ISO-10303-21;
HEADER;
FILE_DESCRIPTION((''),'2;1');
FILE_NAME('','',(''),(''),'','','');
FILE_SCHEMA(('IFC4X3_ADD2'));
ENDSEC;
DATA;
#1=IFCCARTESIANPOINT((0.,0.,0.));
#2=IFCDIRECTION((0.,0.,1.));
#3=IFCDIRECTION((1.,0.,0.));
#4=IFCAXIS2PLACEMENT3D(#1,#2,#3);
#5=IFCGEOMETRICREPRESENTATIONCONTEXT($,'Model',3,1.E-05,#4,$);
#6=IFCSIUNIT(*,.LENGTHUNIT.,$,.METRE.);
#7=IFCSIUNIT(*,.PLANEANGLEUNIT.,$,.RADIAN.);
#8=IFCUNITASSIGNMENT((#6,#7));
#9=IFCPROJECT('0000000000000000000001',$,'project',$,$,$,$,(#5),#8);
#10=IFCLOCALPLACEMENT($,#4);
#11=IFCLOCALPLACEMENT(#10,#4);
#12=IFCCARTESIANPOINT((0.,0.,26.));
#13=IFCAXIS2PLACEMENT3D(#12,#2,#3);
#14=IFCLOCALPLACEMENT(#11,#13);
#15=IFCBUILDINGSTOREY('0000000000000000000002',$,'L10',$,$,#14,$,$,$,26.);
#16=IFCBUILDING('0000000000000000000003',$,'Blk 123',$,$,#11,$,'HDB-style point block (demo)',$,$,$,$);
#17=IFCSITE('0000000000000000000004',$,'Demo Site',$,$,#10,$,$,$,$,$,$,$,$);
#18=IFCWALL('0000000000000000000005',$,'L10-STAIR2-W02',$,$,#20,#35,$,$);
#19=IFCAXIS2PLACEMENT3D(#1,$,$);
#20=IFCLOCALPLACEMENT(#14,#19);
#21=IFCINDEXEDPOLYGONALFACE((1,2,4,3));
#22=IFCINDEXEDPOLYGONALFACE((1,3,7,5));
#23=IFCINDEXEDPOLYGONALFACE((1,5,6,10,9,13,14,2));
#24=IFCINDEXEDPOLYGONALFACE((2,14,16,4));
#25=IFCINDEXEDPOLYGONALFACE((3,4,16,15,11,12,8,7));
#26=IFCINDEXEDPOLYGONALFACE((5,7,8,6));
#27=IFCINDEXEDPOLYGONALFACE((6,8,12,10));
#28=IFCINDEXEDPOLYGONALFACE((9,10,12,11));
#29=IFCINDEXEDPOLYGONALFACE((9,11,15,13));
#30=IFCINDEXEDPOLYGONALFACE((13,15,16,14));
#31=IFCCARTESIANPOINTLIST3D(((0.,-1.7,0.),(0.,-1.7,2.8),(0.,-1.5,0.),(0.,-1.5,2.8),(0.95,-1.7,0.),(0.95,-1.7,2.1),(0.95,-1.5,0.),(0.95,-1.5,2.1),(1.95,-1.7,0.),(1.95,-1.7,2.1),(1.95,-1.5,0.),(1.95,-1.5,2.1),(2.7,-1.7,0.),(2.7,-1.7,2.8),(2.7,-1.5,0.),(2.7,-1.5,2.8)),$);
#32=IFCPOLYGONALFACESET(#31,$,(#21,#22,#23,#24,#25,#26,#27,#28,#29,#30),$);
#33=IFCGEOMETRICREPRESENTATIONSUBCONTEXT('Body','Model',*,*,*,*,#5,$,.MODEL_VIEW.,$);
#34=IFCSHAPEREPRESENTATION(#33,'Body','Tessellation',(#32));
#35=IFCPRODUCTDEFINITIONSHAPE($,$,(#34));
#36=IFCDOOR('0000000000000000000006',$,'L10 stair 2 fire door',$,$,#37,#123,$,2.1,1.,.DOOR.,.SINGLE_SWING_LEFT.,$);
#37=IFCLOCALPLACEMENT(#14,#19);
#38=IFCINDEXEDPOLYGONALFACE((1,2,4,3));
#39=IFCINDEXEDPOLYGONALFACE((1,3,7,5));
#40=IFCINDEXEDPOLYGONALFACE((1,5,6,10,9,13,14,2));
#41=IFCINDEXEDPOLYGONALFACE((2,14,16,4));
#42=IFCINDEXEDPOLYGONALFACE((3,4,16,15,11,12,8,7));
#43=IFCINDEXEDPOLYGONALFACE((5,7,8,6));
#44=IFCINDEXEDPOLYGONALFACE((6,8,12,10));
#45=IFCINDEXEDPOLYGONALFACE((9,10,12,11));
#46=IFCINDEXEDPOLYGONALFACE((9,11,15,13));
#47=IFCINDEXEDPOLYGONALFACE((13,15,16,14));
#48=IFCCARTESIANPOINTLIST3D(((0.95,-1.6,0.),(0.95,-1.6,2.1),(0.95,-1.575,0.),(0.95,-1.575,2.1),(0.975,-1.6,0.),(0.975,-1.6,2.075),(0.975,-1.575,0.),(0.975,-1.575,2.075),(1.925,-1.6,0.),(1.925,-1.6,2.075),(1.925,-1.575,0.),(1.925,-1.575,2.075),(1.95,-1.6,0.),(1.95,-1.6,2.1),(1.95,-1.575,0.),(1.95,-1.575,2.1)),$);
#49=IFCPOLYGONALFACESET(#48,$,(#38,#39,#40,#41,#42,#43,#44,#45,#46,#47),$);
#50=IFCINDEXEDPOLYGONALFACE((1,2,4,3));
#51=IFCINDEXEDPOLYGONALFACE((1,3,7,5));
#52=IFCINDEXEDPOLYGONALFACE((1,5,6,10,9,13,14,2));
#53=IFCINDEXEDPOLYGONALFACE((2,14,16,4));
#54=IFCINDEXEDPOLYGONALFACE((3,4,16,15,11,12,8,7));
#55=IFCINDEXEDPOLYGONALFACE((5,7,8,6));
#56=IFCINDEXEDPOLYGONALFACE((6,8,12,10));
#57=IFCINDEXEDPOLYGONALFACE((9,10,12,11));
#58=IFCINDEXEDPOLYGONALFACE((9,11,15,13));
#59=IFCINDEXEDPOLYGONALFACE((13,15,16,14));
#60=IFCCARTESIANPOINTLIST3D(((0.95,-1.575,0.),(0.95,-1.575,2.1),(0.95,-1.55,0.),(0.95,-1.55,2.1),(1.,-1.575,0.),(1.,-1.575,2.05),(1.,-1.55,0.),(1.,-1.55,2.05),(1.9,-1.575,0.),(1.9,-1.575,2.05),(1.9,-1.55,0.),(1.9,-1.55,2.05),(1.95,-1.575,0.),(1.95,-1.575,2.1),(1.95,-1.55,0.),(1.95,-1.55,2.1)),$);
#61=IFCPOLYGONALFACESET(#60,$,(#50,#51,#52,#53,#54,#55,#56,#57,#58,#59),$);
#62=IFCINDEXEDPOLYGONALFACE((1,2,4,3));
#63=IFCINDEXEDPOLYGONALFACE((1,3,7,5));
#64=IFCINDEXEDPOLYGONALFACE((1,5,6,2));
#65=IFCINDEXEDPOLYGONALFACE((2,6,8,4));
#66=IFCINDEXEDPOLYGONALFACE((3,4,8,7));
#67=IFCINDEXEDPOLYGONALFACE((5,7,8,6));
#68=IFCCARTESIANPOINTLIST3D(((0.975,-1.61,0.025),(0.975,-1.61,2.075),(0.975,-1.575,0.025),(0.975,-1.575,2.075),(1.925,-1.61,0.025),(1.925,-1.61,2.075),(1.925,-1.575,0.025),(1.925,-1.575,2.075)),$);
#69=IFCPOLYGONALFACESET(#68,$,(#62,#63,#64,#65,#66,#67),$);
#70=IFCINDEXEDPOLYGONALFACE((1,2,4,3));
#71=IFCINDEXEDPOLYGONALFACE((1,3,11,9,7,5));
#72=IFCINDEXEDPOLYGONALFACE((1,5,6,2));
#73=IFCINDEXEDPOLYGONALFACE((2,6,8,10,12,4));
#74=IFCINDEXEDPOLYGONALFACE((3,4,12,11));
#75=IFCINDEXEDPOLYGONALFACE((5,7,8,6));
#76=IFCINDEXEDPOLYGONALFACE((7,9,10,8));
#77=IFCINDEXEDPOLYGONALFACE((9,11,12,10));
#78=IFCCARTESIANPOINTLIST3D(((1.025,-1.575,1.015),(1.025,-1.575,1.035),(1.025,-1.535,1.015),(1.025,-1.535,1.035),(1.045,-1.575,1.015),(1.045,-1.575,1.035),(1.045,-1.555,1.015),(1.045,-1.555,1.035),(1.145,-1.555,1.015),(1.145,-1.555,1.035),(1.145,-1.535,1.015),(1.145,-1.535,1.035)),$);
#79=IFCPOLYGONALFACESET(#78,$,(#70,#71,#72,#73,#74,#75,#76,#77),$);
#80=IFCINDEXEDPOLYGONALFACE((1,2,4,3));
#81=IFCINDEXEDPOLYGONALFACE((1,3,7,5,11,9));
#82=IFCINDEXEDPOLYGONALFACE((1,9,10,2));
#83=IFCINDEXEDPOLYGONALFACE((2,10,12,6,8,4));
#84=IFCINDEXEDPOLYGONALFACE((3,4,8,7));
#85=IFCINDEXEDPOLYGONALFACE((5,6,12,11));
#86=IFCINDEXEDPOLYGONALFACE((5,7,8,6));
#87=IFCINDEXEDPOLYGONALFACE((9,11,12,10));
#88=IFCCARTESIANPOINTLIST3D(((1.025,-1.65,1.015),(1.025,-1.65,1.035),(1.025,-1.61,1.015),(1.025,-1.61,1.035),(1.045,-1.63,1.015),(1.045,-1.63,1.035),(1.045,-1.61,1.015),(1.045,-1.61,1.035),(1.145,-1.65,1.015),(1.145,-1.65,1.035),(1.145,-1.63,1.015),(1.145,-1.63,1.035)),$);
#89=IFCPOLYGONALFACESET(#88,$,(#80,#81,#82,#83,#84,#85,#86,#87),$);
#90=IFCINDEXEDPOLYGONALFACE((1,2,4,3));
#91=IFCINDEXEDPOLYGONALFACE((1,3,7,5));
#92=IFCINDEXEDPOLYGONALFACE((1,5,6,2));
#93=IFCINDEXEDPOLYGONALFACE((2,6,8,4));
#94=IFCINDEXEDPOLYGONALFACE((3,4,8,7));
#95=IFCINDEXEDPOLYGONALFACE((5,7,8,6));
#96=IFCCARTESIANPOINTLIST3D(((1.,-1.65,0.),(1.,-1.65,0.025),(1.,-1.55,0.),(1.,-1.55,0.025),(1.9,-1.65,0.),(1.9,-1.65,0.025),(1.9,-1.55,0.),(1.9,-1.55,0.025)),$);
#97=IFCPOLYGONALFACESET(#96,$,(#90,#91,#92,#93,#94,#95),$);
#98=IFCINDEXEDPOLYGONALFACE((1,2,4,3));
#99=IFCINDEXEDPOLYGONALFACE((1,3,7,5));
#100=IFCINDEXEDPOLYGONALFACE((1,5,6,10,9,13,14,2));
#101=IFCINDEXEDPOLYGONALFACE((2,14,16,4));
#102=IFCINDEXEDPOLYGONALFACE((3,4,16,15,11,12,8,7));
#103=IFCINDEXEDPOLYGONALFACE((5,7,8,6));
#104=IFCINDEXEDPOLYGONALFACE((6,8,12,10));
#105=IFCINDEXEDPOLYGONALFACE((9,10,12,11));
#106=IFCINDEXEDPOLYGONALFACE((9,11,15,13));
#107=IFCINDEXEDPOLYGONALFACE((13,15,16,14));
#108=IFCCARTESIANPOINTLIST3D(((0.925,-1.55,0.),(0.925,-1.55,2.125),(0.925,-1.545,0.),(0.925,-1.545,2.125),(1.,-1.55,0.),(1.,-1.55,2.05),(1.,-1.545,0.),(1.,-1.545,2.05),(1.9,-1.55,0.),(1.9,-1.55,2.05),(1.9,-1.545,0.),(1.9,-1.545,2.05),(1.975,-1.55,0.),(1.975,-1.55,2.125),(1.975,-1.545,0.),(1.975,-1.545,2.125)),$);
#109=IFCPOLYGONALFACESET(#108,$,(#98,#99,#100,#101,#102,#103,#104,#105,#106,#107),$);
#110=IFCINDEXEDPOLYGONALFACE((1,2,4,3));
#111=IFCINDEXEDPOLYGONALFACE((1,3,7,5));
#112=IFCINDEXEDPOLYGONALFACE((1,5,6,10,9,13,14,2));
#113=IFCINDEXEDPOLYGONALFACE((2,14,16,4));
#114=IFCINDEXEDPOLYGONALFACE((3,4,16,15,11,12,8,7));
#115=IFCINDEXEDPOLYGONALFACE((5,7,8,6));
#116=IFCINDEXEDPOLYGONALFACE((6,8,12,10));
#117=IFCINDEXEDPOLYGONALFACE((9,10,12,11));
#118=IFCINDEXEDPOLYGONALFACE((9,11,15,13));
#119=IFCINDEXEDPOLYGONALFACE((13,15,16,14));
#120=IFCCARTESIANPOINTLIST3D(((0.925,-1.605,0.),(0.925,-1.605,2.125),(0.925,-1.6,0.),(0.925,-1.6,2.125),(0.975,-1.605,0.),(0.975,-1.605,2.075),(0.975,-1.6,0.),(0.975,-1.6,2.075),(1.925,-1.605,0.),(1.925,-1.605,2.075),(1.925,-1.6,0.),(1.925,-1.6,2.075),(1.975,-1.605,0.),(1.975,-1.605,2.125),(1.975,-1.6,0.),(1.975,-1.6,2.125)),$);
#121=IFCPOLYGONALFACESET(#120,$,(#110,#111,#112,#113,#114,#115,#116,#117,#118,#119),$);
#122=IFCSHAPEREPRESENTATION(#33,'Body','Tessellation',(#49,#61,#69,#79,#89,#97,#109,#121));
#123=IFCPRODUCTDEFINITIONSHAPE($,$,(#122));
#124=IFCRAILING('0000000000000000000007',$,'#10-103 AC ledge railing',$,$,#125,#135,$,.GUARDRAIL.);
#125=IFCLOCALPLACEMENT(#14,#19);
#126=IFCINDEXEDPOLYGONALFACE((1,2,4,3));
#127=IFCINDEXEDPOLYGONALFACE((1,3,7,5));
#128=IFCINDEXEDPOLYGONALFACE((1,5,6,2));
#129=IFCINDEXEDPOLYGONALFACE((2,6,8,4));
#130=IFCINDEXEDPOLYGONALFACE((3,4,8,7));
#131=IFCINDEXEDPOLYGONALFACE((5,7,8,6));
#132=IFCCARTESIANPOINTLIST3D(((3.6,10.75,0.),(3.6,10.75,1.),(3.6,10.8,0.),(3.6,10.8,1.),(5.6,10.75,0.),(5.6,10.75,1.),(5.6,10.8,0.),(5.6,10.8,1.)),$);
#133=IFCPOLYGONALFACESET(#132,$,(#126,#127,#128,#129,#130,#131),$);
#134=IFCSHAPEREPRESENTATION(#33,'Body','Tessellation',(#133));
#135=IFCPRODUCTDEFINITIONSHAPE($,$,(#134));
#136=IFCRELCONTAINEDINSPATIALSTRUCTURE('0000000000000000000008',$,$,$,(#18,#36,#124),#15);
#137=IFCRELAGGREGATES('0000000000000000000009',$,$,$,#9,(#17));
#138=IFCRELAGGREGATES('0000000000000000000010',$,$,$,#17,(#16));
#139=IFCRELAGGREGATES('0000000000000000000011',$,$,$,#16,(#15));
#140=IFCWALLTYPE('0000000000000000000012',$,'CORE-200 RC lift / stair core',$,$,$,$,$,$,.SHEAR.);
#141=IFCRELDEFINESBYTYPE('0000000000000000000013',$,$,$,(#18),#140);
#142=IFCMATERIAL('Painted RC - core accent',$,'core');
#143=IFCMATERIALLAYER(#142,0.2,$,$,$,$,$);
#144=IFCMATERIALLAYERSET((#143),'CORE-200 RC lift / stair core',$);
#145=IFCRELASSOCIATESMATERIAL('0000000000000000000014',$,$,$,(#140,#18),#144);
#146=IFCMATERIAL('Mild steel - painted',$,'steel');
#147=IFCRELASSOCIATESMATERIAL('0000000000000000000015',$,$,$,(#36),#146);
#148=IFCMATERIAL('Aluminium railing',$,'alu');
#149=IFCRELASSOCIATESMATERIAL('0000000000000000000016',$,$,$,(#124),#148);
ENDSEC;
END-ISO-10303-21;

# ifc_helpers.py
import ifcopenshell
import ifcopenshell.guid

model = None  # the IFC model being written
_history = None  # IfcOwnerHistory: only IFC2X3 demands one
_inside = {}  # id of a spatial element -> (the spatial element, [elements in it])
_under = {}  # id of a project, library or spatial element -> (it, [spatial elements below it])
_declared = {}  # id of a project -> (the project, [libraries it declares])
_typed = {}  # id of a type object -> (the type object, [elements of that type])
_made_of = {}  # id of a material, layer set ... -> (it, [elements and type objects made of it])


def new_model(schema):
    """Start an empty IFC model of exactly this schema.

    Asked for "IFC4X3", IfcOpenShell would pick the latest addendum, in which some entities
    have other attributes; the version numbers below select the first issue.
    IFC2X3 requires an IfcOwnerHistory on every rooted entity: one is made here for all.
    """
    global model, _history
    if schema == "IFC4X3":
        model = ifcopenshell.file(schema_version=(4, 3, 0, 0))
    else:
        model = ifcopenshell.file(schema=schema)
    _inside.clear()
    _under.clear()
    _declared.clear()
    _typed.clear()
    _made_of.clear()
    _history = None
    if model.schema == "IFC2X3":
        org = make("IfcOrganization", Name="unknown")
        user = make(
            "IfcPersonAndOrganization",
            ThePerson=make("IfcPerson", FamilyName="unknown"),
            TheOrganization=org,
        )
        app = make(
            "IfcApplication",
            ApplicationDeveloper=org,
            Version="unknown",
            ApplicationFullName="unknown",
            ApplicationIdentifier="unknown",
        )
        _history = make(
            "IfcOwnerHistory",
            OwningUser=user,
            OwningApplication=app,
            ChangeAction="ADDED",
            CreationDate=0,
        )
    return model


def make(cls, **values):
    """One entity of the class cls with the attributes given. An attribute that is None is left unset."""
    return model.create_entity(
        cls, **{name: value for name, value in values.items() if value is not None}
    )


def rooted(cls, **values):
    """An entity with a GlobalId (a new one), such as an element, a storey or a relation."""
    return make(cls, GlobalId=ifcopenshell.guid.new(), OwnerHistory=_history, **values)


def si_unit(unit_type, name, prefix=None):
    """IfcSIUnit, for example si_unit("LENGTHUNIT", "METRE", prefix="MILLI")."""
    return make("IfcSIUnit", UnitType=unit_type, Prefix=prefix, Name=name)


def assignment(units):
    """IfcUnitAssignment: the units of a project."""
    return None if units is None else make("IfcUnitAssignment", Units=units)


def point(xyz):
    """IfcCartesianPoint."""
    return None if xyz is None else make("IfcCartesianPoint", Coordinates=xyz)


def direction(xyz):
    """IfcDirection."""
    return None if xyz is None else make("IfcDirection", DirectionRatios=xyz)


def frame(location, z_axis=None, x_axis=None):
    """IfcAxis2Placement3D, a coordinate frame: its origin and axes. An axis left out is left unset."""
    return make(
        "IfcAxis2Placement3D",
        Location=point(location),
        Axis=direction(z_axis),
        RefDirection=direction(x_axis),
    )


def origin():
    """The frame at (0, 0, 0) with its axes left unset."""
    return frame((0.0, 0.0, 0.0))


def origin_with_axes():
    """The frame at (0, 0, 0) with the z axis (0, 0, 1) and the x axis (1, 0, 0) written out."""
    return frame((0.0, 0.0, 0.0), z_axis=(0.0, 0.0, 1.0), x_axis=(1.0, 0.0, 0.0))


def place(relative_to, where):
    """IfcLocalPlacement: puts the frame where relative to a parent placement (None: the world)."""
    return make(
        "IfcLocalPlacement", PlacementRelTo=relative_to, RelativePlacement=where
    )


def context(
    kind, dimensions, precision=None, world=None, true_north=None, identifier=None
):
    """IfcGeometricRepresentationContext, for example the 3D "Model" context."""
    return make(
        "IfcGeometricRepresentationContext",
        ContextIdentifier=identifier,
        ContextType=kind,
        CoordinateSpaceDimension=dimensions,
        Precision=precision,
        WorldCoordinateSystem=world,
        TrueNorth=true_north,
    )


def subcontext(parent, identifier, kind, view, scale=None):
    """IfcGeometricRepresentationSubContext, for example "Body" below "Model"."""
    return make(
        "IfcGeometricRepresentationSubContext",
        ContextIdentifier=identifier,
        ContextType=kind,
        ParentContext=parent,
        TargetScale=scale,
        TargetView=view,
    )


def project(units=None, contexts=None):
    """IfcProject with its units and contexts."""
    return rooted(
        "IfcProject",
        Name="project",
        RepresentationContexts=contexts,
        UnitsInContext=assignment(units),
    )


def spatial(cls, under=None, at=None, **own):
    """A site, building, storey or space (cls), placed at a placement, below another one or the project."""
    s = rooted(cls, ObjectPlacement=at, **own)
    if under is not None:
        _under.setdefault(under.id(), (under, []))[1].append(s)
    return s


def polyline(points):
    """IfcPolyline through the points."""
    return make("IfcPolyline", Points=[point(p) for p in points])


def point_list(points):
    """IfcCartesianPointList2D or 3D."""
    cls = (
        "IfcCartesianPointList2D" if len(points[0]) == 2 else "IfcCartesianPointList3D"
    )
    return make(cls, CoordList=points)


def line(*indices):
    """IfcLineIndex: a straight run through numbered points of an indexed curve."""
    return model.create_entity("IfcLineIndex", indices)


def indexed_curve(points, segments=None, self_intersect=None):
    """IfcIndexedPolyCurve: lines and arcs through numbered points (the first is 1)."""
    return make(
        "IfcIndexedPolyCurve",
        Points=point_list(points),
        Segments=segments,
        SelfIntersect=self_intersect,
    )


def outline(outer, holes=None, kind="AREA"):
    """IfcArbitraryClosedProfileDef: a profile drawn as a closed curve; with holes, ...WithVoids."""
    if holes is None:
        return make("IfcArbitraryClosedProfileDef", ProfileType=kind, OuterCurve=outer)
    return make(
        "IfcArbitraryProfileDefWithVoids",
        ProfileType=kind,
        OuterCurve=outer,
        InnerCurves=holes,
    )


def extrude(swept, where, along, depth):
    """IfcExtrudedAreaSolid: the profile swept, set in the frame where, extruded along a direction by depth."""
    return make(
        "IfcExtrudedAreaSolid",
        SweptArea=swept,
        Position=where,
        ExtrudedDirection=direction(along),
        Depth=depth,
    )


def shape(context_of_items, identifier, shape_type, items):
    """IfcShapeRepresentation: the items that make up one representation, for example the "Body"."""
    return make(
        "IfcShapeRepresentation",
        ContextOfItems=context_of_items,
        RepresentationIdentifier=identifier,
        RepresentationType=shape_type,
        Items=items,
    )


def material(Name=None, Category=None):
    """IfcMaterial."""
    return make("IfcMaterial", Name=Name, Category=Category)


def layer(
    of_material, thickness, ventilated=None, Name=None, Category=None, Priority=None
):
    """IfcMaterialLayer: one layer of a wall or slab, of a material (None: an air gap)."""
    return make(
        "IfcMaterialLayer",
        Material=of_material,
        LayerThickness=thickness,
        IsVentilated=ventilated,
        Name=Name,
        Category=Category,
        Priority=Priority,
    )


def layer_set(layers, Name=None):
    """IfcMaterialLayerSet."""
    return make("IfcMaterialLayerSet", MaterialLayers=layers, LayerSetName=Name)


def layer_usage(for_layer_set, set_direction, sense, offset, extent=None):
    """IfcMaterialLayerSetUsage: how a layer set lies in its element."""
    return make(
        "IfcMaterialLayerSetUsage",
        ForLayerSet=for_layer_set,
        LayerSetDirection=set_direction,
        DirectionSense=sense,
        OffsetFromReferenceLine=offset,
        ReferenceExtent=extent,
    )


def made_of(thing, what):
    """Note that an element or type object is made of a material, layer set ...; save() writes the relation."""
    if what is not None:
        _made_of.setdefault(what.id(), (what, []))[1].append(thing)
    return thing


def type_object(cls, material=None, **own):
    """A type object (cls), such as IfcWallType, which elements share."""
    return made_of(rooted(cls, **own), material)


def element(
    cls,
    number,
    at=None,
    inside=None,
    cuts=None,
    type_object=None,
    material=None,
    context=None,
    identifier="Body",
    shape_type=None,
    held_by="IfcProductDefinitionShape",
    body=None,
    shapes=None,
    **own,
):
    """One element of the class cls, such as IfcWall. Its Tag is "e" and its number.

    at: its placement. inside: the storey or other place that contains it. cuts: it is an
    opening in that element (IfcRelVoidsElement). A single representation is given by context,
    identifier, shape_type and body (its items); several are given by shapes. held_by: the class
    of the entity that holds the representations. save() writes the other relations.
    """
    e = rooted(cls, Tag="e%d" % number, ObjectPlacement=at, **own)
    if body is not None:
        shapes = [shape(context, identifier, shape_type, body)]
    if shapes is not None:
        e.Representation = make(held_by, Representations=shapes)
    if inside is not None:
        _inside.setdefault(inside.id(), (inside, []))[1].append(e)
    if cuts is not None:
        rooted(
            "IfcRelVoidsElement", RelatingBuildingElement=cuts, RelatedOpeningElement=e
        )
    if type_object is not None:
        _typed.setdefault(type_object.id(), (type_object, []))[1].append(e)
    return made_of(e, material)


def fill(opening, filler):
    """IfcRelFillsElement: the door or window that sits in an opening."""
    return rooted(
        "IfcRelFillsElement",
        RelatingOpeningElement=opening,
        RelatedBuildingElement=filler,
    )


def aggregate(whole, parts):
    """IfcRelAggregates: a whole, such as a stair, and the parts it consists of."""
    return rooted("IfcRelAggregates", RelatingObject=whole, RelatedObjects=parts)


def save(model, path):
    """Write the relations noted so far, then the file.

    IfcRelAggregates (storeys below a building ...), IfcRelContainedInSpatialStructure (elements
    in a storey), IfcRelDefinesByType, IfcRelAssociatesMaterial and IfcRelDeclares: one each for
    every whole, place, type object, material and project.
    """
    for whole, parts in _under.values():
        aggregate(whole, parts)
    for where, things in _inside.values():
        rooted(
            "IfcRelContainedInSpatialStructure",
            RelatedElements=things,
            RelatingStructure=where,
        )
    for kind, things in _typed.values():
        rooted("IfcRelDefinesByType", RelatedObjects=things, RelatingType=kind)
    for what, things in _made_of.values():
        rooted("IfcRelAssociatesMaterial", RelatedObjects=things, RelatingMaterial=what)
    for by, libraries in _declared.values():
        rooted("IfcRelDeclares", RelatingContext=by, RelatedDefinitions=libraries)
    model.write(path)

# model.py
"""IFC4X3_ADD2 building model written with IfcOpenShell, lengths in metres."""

from ifc_helpers import new_model, si_unit, frame, origin, origin_with_axes, place, context, subcontext, project, spatial, polyline, line, indexed_curve, outline, extrude, material, layer, layer_set, layer_usage, type_object, element, fill, save


model = new_model("IFC4X3_ADD2")

# Units and contexts
model_context = context("Model", 3, precision=1e-05, world=origin_with_axes())
body_context = subcontext(model_context, "Body", "Model", "MODEL_VIEW")
ifc_project = project(units=[si_unit("LENGTHUNIT", "METRE"), si_unit("PLANEANGLEUNIT", "RADIAN")], contexts=[model_context])

# Site, building, storey
site_placement = place(None, origin_with_axes())
site = spatial("IfcSite", under=ifc_project, at=site_placement, Name="Demo Site")
building_placement = place(site_placement, origin_with_axes())
building = spatial("IfcBuilding", under=site, at=building_placement, Name="Blk 123", LongName="HDB-style point block (demo)")
storey_placement = place(building_placement, frame((0.0, 0.0, 26.0), z_axis=(0.0, 0.0, 1.0), x_axis=(1.0, 0.0, 0.0)))
storey = spatial("IfcBuildingStorey", under=building, at=storey_placement, Name="L10", Elevation=26.0)

# Shared definitions
ifc_material_1 = material(Name="Painted RC - core accent", Category="core")
ifc_layer_1 = layer(ifc_material_1, 0.2)
ifc_layer_set_1 = layer_set([ifc_layer_1], Name="CORE-200 RC lift / stair core")
ifc_layer_usage_1 = layer_usage(ifc_layer_set_1, "AXIS2", "POSITIVE", 0.0)
wall_type_1 = type_object("IfcWallType", Name="CORE-200 RC lift / stair core", PredefinedType="SHEAR", material=ifc_layer_set_1)

# Wall, opening, door
wall_1_placement = place(storey_placement, frame((2.7, -1.5, 0.0), z_axis=(0.0, 0.0, 1.0), x_axis=(-1.0, 0.0, 0.0)))
wall_1 = element("IfcWall", 1, at=wall_1_placement, inside=storey, type_object=wall_type_1, material=ifc_layer_usage_1, Name="L10-STAIR2-W02", context=body_context, shape_type="SweptSolid", body=[
    extrude(outline(indexed_curve([(0.0, 0.0), (0.0, 0.2), (2.7, 0.2), (2.7, 0.0), (0.0, 0.0)], self_intersect=False)), origin_with_axes(), (0.0, 0.0, 1.0), 2.8),
])
opening_1_placement = place(wall_1_placement, frame((0.75, -0.1, 0.0), z_axis=(0.0, 0.0, 1.0), x_axis=(1.0, 0.0, 0.0)))
opening_1 = element("IfcOpeningElement", 2, at=opening_1_placement, cuts=wall_1, context=body_context, shape_type="SweptSolid", body=[
    extrude(outline(indexed_curve([(0.0, 0.0), (0.0, 0.4), (1.0, 0.4), (1.0, 0.0), (0.0, 0.0)], self_intersect=False)), origin_with_axes(), (0.0, 0.0, 1.0), 2.1),
])
ifc_material_2 = material(Name="Mild steel - painted", Category="steel")
door_1_placement = place(opening_1_placement, frame((0.0, 0.15, 0.0), z_axis=(0.0, 0.0, 1.0), x_axis=(1.0, 0.0, 0.0)))
door_1 = element("IfcDoor", 3, at=door_1_placement, inside=storey, material=ifc_material_2, Name="L10 stair 2 fire door", OperationType="SINGLE_SWING_LEFT", OverallHeight=2.1, OverallWidth=1.0, PredefinedType="DOOR", context=body_context, shape_type="SweptSolid", body=[
    extrude(outline(indexed_curve([(0.0, 0.0), (0.0, 2.1), (1.0, 2.1), (1.0, 0.0), (0.975, 0.0), (0.975, 2.075), (0.025, 2.075), (0.025, 0.0)], segments=[line(1, 2, 3, 4, 5, 6, 7, 8, 1)])), frame((0.0, 0.025, 0.0), z_axis=(0.0, -1.0, 0.0), x_axis=(1.0, 0.0, 0.0)), (0.0, 0.0, -1.0), 0.025),
    extrude(outline(indexed_curve([(0.0, 0.0), (0.0, 2.1), (1.0, 2.1), (1.0, 0.0), (0.95, 0.0), (0.95, 2.05), (0.05, 2.05), (0.05, 0.0)], segments=[line(1, 2, 3, 4, 5, 6, 7, 8, 1)])), frame((0.0, 0.0, 0.0), z_axis=(0.0, -1.0, 0.0), x_axis=(1.0, 0.0, 0.0)), (0.0, 0.0, -1.0), 0.025),
    extrude(outline(indexed_curve([(0.0, 0.0), (0.95, 0.0), (0.95, 0.035), (0.0, 0.035)], segments=[line(1, 2, 3, 4, 1)])), frame((0.025, 0.025, 0.025), z_axis=(0.0, 0.0, 1.0), x_axis=(1.0, 0.0, 0.0)), (0.0, 0.0, 1.0), 2.05),
    extrude(outline(indexed_curve([(0.0, 0.0), (0.0, -0.04), (-0.12, -0.04), (-0.12, -0.02), (-0.02, -0.02), (-0.02, 0.0)], segments=[line(1, 2, 3, 4, 5, 6, 1)])), frame((0.925, 0.025, 1.015), z_axis=(0.0, 0.0, 1.0), x_axis=(1.0, 0.0, 0.0)), (0.0, 0.0, 1.0), 0.02),
    extrude(outline(indexed_curve([(0.0, 0.0), (0.0, 0.04), (-0.12, 0.04), (-0.12, 0.02), (-0.02, 0.02), (-0.02, 0.0)], segments=[line(1, 2, 3, 4, 5, 6, 1)])), frame((0.925, 0.06, 1.015), z_axis=(0.0, 0.0, 1.0), x_axis=(1.0, 0.0, 0.0)), (0.0, 0.0, 1.0), 0.02),
    extrude(outline(indexed_curve([(0.0, 0.0), (0.9, 0.0), (0.9, 0.1), (0.0, 0.1)], segments=[line(1, 2, 3, 4, 1)])), frame((0.05, 0.0, 0.0), z_axis=(0.0, 0.0, 1.0), x_axis=(1.0, 0.0, 0.0)), (0.0, 0.0, 1.0), 0.025),
    extrude(outline(indexed_curve([(0.0, 0.0), (0.0, 2.125), (1.05, 2.125), (1.05, 0.0), (0.975, 0.0), (0.975, 2.05), (0.075, 2.05), (0.075, 0.0)], segments=[line(1, 2, 3, 4, 5, 6, 7, 8, 1)])), frame((-0.025, -0.005, 0.0), z_axis=(0.0, -1.0, 0.0), x_axis=(1.0, 0.0, 0.0)), (0.0, 0.0, -1.0), 0.005),
    extrude(outline(indexed_curve([(0.0, 0.0), (0.0, 2.125), (1.05, 2.125), (1.05, 0.0), (1.0, 0.0), (1.0, 2.075), (0.05, 2.075), (0.05, 0.0)], segments=[line(1, 2, 3, 4, 5, 6, 7, 8, 1)])), frame((-0.025, 0.05, 0.0), z_axis=(0.0, -1.0, 0.0), x_axis=(1.0, 0.0, 0.0)), (0.0, 0.0, -1.0), 0.005),
])
fill(opening_1, door_1)

# Railing
ifc_material_3 = material(Name="Aluminium railing", Category="alu")
railing_placement = place(storey_placement, frame((4.6, 10.775, 0.0), z_axis=(0.0, 0.0, 1.0), x_axis=(1.0, 0.0, 0.0)))
element("IfcRailing", 4, at=railing_placement, inside=storey, material=ifc_material_3, Name="#10-103 AC ledge railing", PredefinedType="GUARDRAIL", context=body_context, shape_type="SweptSolid", body=[
    extrude(outline(polyline([(1.0, -0.025), (1.0, 0.025), (-1.0, 0.025), (-1.0, -0.025), (1.0, -0.025)])), origin(), (0.0, 0.0, 1.0), 1.0),
])

save(model, "model.ifc")
